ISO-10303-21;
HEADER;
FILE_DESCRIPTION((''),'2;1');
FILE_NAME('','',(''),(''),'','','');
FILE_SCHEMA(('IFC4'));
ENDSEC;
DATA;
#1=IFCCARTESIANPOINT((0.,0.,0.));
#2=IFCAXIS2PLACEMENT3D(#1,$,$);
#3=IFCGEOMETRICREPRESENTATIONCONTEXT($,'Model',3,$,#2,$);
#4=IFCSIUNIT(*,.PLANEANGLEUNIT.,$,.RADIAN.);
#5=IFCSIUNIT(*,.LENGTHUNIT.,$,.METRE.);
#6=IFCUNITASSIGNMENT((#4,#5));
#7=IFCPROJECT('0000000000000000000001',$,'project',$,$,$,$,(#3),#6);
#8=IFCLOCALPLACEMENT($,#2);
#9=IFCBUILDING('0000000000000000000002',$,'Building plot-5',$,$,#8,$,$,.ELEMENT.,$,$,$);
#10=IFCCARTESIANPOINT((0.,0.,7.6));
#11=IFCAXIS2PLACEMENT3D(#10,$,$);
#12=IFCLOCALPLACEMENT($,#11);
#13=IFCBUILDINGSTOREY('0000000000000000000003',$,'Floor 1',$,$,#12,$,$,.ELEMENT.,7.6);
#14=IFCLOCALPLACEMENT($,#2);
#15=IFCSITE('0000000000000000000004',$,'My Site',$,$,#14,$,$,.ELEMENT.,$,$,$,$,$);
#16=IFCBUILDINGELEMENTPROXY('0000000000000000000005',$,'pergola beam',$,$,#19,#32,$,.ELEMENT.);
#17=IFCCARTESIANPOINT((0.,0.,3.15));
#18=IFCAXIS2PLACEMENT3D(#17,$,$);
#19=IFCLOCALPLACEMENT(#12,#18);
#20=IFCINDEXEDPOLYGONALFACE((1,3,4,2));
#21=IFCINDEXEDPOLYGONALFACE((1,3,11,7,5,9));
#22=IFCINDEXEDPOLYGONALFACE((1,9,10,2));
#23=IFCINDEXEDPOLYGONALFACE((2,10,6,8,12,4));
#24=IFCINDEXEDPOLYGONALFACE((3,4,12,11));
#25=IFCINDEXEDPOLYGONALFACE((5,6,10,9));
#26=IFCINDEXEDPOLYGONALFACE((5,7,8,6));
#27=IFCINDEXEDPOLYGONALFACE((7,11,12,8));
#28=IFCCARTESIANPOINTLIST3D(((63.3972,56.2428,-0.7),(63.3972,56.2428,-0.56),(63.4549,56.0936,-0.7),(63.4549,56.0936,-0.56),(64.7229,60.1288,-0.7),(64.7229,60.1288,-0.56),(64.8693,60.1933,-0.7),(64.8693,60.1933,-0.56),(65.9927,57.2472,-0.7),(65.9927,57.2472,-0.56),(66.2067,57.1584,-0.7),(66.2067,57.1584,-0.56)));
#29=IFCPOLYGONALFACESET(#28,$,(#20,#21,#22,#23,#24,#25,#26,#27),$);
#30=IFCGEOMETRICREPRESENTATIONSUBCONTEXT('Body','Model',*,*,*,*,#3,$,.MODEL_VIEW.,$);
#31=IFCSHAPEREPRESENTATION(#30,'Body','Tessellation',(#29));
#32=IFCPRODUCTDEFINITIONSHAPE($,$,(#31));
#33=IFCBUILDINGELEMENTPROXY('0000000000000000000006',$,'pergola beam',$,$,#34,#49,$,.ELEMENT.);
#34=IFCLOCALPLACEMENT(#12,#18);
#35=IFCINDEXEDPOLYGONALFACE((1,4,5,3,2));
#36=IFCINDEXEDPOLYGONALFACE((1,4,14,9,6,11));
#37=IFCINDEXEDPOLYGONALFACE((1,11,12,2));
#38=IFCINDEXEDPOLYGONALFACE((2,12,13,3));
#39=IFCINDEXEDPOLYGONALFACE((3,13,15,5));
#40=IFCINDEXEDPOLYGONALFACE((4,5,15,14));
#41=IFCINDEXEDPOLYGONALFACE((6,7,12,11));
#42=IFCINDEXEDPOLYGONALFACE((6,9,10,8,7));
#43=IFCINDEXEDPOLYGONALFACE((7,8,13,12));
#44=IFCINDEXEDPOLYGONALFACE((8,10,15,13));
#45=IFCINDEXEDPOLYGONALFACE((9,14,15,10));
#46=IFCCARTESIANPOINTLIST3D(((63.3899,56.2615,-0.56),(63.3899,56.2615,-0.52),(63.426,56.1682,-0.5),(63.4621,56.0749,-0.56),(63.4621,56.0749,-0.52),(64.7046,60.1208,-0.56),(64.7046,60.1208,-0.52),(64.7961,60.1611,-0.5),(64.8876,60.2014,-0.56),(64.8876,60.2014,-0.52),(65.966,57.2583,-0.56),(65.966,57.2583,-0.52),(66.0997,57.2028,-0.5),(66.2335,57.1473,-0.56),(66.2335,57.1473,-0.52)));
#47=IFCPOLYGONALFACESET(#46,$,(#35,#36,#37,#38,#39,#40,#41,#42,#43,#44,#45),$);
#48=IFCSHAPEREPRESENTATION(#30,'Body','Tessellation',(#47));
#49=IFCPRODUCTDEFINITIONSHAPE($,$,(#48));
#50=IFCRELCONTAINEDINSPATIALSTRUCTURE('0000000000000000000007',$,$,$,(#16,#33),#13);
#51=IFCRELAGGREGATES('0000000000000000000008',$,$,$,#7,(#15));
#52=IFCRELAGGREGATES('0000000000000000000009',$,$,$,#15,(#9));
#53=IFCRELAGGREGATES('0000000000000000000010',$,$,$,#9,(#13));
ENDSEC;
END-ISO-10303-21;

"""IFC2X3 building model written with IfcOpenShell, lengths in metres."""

from ifc_helpers import new_model, entity, si_unit, frame, origin, place, context, subcontext, project, spatial, element, save


model = new_model("IFC2X3")

# Units and contexts
model_context = context("Model", 3, world=origin())
body_context = subcontext(model_context, "Body", "Model", "MODEL_VIEW")
ifc_project = project(units=[si_unit("PLANEANGLEUNIT", "RADIAN"), si_unit("LENGTHUNIT", "METRE")], contexts=[model_context])

# Site, building, storey
site_placement = place(None, origin())
site = spatial("IfcSite", under=ifc_project, at=site_placement, Name="My Site", CompositionType="ELEMENT")
building_placement = place(None, origin())
building = spatial("IfcBuilding", under=site, at=building_placement, Name="Building plot-5", CompositionType="ELEMENT")
storey_placement = place(None, frame((0.0, 0.0, 7.6)))
storey = spatial("IfcBuildingStorey", under=building, at=storey_placement, Name="Floor 1", CompositionType="ELEMENT", Elevation=7.6)

# Building element proxies
proxy_1_placement = place(storey_placement, frame((0.0, 0.0, 3.15)))
axis2_placement3_d_1 = entity("IfcAxis2Placement3D", entity("IfcCartesianPoint", [0.0, 0.0, 0.0]))
element("IfcBuildingElementProxy", 1, at=proxy_1_placement, inside=storey, Name="pergola beam", CompositionType="ELEMENT", context=body_context, shape_type="SweptSolid", held_by="IfcProductRepresentation", body=[
    entity("IfcSurfaceCurveSweptAreaSolid", entity("IfcArbitraryClosedProfileDef", "AREA", None, entity("IfcPolyline", [entity("IfcCartesianPoint", [-0.7, -0.08]), entity("IfcCartesianPoint", [-0.7, 0.08]), entity("IfcCartesianPoint", [-0.56, 0.08]), entity("IfcCartesianPoint", [-0.56, -0.08]), entity("IfcCartesianPoint", [-0.7, -0.08])])), axis2_placement3_d_1, entity("IfcPolyline", [entity("IfcCartesianPoint", [63.426, 56.1682]), entity("IfcCartesianPoint", [66.0997, 57.2028]), entity("IfcCartesianPoint", [64.7961, 60.1611])]), 0.0, 1.0, entity("IfcPlane", axis2_placement3_d_1)),
])
proxy_2_placement = place(storey_placement, frame((0.0, 0.0, 3.15)))
axis2_placement3_d_2 = entity("IfcAxis2Placement3D", entity("IfcCartesianPoint", [0.0, 0.0, 0.0]))
element("IfcBuildingElementProxy", 2, at=proxy_2_placement, inside=storey, Name="pergola beam", CompositionType="ELEMENT", context=body_context, shape_type="SweptSolid", held_by="IfcProductRepresentation", body=[
    entity("IfcSurfaceCurveSweptAreaSolid", entity("IfcArbitraryClosedProfileDef", "AREA", None, entity("IfcPolyline", [entity("IfcCartesianPoint", [-0.5, 0.0]), entity("IfcCartesianPoint", [-0.52, -0.1]), entity("IfcCartesianPoint", [-0.56, -0.1]), entity("IfcCartesianPoint", [-0.56, 0.1]), entity("IfcCartesianPoint", [-0.52, 0.1]), entity("IfcCartesianPoint", [-0.5, 0.0])])), axis2_placement3_d_2, entity("IfcPolyline", [entity("IfcCartesianPoint", [63.426, 56.1682]), entity("IfcCartesianPoint", [66.0997, 57.2028]), entity("IfcCartesianPoint", [64.7961, 60.1611])]), 0.0, 1.0, entity("IfcPlane", axis2_placement3_d_2)),
])

save(model, "model.ifc")
